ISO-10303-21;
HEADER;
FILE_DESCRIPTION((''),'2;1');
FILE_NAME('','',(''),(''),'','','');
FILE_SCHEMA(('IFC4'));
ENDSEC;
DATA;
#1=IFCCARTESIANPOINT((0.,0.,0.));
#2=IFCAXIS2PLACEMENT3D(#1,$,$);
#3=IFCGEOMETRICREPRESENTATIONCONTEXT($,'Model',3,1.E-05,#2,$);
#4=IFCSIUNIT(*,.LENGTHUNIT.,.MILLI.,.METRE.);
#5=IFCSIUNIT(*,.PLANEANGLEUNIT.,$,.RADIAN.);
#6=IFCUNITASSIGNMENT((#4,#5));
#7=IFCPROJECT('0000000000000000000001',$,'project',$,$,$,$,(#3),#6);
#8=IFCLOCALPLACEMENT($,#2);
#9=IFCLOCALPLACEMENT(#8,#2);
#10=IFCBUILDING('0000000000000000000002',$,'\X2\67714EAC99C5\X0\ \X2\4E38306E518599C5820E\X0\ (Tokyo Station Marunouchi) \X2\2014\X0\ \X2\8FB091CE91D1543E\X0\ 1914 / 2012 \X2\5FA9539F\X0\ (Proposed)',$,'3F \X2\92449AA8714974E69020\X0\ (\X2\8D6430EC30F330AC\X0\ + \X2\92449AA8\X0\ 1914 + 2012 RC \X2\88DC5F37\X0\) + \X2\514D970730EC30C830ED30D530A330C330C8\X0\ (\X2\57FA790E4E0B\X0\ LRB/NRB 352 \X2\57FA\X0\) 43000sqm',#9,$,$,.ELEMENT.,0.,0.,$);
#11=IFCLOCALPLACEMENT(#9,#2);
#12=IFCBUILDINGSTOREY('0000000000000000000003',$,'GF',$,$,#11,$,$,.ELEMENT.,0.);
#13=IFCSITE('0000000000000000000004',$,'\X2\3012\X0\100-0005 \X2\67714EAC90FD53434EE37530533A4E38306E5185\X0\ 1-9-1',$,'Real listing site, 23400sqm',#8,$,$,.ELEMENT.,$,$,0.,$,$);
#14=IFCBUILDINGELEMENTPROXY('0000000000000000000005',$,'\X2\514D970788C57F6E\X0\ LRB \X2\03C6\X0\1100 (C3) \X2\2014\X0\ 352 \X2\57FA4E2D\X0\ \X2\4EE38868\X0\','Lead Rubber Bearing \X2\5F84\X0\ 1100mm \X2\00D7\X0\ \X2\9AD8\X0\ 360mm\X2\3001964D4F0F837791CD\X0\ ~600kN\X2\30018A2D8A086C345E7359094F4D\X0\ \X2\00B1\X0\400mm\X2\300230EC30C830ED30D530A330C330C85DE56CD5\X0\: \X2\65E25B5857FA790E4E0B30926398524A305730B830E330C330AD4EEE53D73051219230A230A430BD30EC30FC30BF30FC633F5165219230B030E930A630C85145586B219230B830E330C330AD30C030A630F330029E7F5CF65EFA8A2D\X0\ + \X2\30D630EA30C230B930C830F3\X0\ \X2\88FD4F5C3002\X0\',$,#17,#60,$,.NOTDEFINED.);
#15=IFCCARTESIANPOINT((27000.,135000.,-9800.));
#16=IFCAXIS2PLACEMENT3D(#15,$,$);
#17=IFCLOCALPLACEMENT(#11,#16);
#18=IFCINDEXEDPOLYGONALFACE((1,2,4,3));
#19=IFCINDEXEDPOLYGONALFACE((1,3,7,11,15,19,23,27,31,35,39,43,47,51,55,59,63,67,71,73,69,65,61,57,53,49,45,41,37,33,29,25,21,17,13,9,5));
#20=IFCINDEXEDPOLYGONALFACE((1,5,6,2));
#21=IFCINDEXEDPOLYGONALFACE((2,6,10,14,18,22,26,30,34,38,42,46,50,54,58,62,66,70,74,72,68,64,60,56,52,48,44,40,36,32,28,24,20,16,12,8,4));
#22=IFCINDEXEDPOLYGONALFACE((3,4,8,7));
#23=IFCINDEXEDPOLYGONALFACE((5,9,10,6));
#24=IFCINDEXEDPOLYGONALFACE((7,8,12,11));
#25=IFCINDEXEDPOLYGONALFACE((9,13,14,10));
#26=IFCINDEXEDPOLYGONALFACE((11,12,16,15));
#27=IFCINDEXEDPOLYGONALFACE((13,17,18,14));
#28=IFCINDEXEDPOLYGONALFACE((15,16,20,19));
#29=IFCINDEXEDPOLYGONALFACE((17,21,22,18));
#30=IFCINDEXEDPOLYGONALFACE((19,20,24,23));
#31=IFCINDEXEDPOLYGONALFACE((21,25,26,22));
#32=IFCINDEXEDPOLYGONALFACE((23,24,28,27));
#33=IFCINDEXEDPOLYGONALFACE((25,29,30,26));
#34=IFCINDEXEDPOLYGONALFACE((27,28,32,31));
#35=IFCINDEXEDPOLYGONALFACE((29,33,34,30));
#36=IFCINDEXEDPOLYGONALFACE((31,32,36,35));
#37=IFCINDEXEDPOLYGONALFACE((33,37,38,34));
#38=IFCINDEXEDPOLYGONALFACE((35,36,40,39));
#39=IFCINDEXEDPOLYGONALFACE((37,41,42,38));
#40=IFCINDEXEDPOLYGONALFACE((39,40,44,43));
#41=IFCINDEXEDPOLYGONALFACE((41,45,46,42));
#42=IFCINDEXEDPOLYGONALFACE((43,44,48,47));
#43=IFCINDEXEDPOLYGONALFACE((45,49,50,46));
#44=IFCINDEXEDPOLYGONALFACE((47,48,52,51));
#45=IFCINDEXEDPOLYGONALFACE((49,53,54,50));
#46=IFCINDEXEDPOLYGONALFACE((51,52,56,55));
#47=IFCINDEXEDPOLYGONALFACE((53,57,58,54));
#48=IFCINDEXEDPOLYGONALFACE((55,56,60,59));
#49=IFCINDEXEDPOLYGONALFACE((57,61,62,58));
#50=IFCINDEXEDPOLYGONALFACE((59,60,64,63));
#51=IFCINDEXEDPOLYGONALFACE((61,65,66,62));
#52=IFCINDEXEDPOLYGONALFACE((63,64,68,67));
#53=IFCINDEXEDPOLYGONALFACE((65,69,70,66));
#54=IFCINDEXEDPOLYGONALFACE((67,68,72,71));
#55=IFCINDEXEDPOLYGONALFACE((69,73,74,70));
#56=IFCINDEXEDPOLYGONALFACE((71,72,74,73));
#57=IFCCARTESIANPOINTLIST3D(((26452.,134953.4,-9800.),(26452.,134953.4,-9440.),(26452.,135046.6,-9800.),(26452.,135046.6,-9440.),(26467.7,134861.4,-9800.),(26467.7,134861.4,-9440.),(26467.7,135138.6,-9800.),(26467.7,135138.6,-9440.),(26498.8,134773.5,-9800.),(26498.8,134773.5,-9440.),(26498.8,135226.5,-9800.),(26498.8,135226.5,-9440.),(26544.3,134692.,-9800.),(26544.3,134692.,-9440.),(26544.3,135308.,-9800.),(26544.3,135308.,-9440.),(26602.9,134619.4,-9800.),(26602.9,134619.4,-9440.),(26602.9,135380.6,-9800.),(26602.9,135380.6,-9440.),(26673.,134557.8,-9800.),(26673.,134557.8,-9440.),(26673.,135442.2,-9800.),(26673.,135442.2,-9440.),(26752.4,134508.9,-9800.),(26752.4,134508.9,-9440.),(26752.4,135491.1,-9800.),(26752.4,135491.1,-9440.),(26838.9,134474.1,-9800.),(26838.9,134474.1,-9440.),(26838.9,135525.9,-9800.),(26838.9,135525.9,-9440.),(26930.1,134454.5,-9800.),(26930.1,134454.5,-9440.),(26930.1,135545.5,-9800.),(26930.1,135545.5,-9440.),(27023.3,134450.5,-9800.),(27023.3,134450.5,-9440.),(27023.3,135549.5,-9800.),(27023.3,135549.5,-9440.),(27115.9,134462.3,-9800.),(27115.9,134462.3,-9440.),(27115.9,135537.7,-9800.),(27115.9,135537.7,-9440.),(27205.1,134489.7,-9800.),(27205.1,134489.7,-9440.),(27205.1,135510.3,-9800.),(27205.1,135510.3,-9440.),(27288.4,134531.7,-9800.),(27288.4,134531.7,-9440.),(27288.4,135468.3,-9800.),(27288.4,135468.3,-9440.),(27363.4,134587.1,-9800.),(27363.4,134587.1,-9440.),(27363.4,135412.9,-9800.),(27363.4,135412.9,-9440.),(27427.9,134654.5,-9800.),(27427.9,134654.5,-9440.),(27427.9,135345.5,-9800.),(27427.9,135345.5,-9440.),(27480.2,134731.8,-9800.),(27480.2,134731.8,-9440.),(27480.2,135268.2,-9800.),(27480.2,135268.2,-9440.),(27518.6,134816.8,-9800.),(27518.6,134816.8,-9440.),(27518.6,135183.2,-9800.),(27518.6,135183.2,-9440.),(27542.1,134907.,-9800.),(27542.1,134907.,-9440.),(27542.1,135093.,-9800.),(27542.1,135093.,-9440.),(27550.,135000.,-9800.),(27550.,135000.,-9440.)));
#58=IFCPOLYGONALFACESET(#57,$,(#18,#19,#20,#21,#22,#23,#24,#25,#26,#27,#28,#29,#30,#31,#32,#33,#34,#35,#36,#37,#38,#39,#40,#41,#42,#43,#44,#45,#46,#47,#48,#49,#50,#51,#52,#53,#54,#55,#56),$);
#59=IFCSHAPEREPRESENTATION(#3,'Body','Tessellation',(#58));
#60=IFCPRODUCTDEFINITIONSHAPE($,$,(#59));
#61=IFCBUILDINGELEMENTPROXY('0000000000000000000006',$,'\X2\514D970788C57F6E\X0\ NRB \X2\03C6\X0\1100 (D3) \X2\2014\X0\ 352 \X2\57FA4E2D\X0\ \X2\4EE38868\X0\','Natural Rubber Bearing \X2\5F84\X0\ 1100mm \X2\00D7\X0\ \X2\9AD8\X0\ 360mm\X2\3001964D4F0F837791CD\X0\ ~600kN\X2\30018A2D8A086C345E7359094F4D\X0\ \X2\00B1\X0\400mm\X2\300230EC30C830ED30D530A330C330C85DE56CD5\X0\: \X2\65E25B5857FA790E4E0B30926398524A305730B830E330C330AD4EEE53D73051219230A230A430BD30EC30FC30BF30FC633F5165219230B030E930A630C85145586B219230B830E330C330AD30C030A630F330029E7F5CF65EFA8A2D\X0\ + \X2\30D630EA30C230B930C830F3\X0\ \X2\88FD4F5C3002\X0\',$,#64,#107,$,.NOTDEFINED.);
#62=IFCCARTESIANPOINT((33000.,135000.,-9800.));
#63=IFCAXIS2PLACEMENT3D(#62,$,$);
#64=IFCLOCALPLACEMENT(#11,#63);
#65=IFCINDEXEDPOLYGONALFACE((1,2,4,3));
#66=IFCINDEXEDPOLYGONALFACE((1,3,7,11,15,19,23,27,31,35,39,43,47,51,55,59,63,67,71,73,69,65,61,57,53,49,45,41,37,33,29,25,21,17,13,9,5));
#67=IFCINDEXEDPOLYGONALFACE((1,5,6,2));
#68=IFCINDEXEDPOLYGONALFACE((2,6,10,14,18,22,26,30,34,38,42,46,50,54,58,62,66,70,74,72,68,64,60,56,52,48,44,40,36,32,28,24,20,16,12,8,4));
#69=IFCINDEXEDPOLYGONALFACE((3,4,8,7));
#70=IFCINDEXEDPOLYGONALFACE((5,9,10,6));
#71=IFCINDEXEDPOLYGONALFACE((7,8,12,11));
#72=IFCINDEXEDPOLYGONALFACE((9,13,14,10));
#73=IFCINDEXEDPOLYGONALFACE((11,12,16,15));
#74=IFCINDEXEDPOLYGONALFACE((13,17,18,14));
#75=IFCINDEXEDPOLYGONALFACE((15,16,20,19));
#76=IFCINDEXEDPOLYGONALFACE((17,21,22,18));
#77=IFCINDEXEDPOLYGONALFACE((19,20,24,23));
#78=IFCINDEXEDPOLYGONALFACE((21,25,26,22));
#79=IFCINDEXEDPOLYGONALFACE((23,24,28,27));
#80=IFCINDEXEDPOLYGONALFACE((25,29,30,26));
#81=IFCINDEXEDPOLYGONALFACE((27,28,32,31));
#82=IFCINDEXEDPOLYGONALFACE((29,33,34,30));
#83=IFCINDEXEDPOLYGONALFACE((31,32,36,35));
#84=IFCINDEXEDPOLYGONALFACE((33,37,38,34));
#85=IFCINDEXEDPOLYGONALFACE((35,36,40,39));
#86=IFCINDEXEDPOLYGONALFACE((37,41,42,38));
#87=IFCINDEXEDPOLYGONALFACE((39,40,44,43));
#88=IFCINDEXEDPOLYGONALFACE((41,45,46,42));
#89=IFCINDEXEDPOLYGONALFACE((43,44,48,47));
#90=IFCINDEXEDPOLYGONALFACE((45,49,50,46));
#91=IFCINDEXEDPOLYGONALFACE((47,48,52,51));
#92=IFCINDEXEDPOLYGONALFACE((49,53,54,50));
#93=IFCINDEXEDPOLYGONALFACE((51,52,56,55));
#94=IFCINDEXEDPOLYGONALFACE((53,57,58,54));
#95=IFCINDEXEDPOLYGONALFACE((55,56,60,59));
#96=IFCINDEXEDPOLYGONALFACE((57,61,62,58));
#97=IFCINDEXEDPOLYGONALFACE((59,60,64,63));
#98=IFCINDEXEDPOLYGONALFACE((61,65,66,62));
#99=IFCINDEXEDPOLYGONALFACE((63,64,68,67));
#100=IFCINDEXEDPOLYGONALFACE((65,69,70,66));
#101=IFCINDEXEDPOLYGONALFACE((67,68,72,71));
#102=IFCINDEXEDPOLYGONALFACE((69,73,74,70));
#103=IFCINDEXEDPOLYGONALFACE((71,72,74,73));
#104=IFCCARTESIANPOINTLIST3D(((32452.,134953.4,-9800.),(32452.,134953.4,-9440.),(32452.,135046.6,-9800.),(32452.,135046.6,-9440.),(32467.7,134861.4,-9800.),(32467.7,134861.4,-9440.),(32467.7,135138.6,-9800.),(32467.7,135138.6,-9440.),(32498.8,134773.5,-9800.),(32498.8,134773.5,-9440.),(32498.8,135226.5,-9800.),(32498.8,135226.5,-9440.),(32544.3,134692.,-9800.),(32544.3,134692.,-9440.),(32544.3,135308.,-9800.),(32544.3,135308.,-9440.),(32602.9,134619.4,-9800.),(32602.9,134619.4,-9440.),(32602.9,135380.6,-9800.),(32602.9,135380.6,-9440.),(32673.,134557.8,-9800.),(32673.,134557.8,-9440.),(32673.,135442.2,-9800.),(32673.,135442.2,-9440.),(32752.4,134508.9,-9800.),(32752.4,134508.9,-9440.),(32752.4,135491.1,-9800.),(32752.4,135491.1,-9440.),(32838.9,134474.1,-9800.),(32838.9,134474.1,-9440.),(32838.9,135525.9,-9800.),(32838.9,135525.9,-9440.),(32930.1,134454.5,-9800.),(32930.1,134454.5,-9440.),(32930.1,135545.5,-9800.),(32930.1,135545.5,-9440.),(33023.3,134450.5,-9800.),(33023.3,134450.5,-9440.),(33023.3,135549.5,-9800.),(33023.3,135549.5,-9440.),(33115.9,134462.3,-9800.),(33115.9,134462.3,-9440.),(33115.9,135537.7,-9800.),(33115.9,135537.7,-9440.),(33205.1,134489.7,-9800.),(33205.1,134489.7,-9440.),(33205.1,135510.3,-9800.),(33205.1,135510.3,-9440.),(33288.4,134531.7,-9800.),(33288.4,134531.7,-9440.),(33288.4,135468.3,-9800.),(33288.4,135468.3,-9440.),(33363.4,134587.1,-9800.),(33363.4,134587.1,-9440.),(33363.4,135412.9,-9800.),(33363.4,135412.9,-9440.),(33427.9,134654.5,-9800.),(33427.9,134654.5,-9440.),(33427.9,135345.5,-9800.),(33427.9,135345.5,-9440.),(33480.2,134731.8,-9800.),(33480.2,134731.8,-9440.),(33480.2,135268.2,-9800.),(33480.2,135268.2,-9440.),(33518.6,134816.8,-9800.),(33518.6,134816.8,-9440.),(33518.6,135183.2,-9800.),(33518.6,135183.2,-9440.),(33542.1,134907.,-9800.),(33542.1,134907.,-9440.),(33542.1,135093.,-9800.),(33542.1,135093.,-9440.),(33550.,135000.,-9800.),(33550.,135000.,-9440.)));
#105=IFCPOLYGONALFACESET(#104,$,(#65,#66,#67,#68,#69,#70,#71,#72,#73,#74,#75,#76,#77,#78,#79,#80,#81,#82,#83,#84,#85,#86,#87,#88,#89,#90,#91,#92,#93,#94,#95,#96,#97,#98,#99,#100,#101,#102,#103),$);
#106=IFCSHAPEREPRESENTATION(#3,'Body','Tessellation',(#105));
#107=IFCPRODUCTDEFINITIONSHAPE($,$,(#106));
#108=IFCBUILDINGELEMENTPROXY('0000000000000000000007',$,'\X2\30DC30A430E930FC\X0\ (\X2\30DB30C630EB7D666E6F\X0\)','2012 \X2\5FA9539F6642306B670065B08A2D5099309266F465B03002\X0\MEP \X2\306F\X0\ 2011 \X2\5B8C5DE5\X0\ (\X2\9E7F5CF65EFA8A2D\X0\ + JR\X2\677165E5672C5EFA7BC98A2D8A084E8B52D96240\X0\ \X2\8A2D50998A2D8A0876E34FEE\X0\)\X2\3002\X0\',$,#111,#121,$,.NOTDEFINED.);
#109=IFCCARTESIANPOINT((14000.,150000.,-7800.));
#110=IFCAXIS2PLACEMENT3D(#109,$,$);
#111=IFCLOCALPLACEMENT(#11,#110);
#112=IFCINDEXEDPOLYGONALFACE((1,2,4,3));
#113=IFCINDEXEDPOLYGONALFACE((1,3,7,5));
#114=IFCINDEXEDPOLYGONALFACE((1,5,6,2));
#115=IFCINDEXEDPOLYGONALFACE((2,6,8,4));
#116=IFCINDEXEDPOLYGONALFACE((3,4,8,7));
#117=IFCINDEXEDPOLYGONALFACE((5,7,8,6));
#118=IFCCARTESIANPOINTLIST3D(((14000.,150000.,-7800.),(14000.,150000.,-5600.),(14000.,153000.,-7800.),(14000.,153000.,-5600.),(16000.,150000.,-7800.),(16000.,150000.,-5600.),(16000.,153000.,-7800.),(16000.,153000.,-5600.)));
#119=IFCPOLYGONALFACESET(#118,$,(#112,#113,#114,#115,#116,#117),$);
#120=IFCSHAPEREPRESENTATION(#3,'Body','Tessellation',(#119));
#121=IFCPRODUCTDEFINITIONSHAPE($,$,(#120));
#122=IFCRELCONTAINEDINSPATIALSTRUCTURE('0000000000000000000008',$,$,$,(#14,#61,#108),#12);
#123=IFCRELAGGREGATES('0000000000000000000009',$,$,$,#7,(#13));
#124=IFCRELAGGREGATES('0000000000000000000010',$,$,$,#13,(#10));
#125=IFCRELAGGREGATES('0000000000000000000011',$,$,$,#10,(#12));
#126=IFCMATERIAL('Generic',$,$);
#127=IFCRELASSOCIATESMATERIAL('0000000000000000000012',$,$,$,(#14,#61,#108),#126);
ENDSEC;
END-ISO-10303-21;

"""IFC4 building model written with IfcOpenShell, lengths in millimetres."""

from ifc_helpers import new_model, si_unit, frame, frame_2d, origin, origin_2d, place, context, project, spatial, rectangle, circle, extrude, material, element, save


model = new_model("IFC4")

# Units and contexts
model_context = context("Model", 3, precision=1e-05, world=origin())
ifc_project = project(units=[si_unit("LENGTHUNIT", "METRE", prefix="MILLI"), si_unit("PLANEANGLEUNIT", "RADIAN")], contexts=[model_context])

# Site, building, storey
site_placement = place(None, origin())
site = spatial("IfcSite", under=ifc_project, at=site_placement, Name="〒100-0005 東京都千代田区丸の内 1-9-1", ObjectType="Real listing site, 23400sqm", CompositionType="ELEMENT", RefElevation=0.0)
building_placement = place(site_placement, origin())
building = spatial("IfcBuilding", under=site, at=building_placement, Name="東京駅 丸の内駅舎 (Tokyo Station Marunouchi) — 辰野金吾 1914 / 2012 復原 (Proposed)", ObjectType="3F 鉄骨煉瓦造 (赤レンガ + 鉄骨 1914 + 2012 RC 補強) + 免震レトロフィット (基礎下 LRB/NRB 352 基) 43000sqm", CompositionType="ELEMENT", ElevationOfRefHeight=0.0, ElevationOfTerrain=0.0)
storey_placement = place(building_placement, origin())
storey = spatial("IfcBuildingStorey", under=building, at=storey_placement, Name="GF", CompositionType="ELEMENT", Elevation=0.0)

# Building element proxies
ifc_material_1 = material(Name="Generic")
proxy_1_placement = place(storey_placement, frame((27000.0, 135000.0, -9800.0)))
element("IfcBuildingElementProxy", 1, at=proxy_1_placement, inside=storey, material=ifc_material_1, Name="免震装置 LRB φ1100 (C3) — 352 基中 代表", Description="Lead Rubber Bearing 径 1100mm × 高 360mm、降伏荷重 ~600kN、設計水平変位 ±400mm。レトロフィット工法: 既存基礎下を掘削しジャッキ仮受け→アイソレーター挿入→グラウト充填→ジャッキダウン。鹿島建設 + ブリヂストン 製作。", PredefinedType="NOTDEFINED", context=model_context, shape_type="SweptSolid", body=[
    extrude(circle(Radius=550.0, at=origin_2d()), frame((27000.0, 135000.0, -9800.0)), (0.0, 0.0, 1.0), 360.0),
])
proxy_2_placement = place(storey_placement, frame((33000.0, 135000.0, -9800.0)))
element("IfcBuildingElementProxy", 2, at=proxy_2_placement, inside=storey, material=ifc_material_1, Name="免震装置 NRB φ1100 (D3) — 352 基中 代表", Description="Natural Rubber Bearing 径 1100mm × 高 360mm、降伏荷重 ~600kN、設計水平変位 ±400mm。レトロフィット工法: 既存基礎下を掘削しジャッキ仮受け→アイソレーター挿入→グラウト充填→ジャッキダウン。鹿島建設 + ブリヂストン 製作。", PredefinedType="NOTDEFINED", context=model_context, shape_type="SweptSolid", body=[
    extrude(circle(Radius=550.0, at=origin_2d()), frame((33000.0, 135000.0, -9800.0)), (0.0, 0.0, 1.0), 360.0),
])
proxy_3_placement = place(storey_placement, frame((14000.0, 150000.0, -7800.0)))
element("IfcBuildingElementProxy", 3, at=proxy_3_placement, inside=storey, material=ifc_material_1, Name="ボイラー (ホテル給湯)", Description="2012 復原時に最新設備を更新。MEP は 2011 完工 (鹿島建設 + JR東日本建築設計事務所 設備設計監修)。", PredefinedType="NOTDEFINED", context=model_context, shape_type="SweptSolid", body=[
    extrude(rectangle(XDim=2000.0, YDim=3000.0, at=frame_2d((1000.0, 1500.0))), frame((14000.0, 150000.0, -7800.0)), (0.0, 0.0, 1.0), 2200.0),
])

save(model, "model.ifc")
